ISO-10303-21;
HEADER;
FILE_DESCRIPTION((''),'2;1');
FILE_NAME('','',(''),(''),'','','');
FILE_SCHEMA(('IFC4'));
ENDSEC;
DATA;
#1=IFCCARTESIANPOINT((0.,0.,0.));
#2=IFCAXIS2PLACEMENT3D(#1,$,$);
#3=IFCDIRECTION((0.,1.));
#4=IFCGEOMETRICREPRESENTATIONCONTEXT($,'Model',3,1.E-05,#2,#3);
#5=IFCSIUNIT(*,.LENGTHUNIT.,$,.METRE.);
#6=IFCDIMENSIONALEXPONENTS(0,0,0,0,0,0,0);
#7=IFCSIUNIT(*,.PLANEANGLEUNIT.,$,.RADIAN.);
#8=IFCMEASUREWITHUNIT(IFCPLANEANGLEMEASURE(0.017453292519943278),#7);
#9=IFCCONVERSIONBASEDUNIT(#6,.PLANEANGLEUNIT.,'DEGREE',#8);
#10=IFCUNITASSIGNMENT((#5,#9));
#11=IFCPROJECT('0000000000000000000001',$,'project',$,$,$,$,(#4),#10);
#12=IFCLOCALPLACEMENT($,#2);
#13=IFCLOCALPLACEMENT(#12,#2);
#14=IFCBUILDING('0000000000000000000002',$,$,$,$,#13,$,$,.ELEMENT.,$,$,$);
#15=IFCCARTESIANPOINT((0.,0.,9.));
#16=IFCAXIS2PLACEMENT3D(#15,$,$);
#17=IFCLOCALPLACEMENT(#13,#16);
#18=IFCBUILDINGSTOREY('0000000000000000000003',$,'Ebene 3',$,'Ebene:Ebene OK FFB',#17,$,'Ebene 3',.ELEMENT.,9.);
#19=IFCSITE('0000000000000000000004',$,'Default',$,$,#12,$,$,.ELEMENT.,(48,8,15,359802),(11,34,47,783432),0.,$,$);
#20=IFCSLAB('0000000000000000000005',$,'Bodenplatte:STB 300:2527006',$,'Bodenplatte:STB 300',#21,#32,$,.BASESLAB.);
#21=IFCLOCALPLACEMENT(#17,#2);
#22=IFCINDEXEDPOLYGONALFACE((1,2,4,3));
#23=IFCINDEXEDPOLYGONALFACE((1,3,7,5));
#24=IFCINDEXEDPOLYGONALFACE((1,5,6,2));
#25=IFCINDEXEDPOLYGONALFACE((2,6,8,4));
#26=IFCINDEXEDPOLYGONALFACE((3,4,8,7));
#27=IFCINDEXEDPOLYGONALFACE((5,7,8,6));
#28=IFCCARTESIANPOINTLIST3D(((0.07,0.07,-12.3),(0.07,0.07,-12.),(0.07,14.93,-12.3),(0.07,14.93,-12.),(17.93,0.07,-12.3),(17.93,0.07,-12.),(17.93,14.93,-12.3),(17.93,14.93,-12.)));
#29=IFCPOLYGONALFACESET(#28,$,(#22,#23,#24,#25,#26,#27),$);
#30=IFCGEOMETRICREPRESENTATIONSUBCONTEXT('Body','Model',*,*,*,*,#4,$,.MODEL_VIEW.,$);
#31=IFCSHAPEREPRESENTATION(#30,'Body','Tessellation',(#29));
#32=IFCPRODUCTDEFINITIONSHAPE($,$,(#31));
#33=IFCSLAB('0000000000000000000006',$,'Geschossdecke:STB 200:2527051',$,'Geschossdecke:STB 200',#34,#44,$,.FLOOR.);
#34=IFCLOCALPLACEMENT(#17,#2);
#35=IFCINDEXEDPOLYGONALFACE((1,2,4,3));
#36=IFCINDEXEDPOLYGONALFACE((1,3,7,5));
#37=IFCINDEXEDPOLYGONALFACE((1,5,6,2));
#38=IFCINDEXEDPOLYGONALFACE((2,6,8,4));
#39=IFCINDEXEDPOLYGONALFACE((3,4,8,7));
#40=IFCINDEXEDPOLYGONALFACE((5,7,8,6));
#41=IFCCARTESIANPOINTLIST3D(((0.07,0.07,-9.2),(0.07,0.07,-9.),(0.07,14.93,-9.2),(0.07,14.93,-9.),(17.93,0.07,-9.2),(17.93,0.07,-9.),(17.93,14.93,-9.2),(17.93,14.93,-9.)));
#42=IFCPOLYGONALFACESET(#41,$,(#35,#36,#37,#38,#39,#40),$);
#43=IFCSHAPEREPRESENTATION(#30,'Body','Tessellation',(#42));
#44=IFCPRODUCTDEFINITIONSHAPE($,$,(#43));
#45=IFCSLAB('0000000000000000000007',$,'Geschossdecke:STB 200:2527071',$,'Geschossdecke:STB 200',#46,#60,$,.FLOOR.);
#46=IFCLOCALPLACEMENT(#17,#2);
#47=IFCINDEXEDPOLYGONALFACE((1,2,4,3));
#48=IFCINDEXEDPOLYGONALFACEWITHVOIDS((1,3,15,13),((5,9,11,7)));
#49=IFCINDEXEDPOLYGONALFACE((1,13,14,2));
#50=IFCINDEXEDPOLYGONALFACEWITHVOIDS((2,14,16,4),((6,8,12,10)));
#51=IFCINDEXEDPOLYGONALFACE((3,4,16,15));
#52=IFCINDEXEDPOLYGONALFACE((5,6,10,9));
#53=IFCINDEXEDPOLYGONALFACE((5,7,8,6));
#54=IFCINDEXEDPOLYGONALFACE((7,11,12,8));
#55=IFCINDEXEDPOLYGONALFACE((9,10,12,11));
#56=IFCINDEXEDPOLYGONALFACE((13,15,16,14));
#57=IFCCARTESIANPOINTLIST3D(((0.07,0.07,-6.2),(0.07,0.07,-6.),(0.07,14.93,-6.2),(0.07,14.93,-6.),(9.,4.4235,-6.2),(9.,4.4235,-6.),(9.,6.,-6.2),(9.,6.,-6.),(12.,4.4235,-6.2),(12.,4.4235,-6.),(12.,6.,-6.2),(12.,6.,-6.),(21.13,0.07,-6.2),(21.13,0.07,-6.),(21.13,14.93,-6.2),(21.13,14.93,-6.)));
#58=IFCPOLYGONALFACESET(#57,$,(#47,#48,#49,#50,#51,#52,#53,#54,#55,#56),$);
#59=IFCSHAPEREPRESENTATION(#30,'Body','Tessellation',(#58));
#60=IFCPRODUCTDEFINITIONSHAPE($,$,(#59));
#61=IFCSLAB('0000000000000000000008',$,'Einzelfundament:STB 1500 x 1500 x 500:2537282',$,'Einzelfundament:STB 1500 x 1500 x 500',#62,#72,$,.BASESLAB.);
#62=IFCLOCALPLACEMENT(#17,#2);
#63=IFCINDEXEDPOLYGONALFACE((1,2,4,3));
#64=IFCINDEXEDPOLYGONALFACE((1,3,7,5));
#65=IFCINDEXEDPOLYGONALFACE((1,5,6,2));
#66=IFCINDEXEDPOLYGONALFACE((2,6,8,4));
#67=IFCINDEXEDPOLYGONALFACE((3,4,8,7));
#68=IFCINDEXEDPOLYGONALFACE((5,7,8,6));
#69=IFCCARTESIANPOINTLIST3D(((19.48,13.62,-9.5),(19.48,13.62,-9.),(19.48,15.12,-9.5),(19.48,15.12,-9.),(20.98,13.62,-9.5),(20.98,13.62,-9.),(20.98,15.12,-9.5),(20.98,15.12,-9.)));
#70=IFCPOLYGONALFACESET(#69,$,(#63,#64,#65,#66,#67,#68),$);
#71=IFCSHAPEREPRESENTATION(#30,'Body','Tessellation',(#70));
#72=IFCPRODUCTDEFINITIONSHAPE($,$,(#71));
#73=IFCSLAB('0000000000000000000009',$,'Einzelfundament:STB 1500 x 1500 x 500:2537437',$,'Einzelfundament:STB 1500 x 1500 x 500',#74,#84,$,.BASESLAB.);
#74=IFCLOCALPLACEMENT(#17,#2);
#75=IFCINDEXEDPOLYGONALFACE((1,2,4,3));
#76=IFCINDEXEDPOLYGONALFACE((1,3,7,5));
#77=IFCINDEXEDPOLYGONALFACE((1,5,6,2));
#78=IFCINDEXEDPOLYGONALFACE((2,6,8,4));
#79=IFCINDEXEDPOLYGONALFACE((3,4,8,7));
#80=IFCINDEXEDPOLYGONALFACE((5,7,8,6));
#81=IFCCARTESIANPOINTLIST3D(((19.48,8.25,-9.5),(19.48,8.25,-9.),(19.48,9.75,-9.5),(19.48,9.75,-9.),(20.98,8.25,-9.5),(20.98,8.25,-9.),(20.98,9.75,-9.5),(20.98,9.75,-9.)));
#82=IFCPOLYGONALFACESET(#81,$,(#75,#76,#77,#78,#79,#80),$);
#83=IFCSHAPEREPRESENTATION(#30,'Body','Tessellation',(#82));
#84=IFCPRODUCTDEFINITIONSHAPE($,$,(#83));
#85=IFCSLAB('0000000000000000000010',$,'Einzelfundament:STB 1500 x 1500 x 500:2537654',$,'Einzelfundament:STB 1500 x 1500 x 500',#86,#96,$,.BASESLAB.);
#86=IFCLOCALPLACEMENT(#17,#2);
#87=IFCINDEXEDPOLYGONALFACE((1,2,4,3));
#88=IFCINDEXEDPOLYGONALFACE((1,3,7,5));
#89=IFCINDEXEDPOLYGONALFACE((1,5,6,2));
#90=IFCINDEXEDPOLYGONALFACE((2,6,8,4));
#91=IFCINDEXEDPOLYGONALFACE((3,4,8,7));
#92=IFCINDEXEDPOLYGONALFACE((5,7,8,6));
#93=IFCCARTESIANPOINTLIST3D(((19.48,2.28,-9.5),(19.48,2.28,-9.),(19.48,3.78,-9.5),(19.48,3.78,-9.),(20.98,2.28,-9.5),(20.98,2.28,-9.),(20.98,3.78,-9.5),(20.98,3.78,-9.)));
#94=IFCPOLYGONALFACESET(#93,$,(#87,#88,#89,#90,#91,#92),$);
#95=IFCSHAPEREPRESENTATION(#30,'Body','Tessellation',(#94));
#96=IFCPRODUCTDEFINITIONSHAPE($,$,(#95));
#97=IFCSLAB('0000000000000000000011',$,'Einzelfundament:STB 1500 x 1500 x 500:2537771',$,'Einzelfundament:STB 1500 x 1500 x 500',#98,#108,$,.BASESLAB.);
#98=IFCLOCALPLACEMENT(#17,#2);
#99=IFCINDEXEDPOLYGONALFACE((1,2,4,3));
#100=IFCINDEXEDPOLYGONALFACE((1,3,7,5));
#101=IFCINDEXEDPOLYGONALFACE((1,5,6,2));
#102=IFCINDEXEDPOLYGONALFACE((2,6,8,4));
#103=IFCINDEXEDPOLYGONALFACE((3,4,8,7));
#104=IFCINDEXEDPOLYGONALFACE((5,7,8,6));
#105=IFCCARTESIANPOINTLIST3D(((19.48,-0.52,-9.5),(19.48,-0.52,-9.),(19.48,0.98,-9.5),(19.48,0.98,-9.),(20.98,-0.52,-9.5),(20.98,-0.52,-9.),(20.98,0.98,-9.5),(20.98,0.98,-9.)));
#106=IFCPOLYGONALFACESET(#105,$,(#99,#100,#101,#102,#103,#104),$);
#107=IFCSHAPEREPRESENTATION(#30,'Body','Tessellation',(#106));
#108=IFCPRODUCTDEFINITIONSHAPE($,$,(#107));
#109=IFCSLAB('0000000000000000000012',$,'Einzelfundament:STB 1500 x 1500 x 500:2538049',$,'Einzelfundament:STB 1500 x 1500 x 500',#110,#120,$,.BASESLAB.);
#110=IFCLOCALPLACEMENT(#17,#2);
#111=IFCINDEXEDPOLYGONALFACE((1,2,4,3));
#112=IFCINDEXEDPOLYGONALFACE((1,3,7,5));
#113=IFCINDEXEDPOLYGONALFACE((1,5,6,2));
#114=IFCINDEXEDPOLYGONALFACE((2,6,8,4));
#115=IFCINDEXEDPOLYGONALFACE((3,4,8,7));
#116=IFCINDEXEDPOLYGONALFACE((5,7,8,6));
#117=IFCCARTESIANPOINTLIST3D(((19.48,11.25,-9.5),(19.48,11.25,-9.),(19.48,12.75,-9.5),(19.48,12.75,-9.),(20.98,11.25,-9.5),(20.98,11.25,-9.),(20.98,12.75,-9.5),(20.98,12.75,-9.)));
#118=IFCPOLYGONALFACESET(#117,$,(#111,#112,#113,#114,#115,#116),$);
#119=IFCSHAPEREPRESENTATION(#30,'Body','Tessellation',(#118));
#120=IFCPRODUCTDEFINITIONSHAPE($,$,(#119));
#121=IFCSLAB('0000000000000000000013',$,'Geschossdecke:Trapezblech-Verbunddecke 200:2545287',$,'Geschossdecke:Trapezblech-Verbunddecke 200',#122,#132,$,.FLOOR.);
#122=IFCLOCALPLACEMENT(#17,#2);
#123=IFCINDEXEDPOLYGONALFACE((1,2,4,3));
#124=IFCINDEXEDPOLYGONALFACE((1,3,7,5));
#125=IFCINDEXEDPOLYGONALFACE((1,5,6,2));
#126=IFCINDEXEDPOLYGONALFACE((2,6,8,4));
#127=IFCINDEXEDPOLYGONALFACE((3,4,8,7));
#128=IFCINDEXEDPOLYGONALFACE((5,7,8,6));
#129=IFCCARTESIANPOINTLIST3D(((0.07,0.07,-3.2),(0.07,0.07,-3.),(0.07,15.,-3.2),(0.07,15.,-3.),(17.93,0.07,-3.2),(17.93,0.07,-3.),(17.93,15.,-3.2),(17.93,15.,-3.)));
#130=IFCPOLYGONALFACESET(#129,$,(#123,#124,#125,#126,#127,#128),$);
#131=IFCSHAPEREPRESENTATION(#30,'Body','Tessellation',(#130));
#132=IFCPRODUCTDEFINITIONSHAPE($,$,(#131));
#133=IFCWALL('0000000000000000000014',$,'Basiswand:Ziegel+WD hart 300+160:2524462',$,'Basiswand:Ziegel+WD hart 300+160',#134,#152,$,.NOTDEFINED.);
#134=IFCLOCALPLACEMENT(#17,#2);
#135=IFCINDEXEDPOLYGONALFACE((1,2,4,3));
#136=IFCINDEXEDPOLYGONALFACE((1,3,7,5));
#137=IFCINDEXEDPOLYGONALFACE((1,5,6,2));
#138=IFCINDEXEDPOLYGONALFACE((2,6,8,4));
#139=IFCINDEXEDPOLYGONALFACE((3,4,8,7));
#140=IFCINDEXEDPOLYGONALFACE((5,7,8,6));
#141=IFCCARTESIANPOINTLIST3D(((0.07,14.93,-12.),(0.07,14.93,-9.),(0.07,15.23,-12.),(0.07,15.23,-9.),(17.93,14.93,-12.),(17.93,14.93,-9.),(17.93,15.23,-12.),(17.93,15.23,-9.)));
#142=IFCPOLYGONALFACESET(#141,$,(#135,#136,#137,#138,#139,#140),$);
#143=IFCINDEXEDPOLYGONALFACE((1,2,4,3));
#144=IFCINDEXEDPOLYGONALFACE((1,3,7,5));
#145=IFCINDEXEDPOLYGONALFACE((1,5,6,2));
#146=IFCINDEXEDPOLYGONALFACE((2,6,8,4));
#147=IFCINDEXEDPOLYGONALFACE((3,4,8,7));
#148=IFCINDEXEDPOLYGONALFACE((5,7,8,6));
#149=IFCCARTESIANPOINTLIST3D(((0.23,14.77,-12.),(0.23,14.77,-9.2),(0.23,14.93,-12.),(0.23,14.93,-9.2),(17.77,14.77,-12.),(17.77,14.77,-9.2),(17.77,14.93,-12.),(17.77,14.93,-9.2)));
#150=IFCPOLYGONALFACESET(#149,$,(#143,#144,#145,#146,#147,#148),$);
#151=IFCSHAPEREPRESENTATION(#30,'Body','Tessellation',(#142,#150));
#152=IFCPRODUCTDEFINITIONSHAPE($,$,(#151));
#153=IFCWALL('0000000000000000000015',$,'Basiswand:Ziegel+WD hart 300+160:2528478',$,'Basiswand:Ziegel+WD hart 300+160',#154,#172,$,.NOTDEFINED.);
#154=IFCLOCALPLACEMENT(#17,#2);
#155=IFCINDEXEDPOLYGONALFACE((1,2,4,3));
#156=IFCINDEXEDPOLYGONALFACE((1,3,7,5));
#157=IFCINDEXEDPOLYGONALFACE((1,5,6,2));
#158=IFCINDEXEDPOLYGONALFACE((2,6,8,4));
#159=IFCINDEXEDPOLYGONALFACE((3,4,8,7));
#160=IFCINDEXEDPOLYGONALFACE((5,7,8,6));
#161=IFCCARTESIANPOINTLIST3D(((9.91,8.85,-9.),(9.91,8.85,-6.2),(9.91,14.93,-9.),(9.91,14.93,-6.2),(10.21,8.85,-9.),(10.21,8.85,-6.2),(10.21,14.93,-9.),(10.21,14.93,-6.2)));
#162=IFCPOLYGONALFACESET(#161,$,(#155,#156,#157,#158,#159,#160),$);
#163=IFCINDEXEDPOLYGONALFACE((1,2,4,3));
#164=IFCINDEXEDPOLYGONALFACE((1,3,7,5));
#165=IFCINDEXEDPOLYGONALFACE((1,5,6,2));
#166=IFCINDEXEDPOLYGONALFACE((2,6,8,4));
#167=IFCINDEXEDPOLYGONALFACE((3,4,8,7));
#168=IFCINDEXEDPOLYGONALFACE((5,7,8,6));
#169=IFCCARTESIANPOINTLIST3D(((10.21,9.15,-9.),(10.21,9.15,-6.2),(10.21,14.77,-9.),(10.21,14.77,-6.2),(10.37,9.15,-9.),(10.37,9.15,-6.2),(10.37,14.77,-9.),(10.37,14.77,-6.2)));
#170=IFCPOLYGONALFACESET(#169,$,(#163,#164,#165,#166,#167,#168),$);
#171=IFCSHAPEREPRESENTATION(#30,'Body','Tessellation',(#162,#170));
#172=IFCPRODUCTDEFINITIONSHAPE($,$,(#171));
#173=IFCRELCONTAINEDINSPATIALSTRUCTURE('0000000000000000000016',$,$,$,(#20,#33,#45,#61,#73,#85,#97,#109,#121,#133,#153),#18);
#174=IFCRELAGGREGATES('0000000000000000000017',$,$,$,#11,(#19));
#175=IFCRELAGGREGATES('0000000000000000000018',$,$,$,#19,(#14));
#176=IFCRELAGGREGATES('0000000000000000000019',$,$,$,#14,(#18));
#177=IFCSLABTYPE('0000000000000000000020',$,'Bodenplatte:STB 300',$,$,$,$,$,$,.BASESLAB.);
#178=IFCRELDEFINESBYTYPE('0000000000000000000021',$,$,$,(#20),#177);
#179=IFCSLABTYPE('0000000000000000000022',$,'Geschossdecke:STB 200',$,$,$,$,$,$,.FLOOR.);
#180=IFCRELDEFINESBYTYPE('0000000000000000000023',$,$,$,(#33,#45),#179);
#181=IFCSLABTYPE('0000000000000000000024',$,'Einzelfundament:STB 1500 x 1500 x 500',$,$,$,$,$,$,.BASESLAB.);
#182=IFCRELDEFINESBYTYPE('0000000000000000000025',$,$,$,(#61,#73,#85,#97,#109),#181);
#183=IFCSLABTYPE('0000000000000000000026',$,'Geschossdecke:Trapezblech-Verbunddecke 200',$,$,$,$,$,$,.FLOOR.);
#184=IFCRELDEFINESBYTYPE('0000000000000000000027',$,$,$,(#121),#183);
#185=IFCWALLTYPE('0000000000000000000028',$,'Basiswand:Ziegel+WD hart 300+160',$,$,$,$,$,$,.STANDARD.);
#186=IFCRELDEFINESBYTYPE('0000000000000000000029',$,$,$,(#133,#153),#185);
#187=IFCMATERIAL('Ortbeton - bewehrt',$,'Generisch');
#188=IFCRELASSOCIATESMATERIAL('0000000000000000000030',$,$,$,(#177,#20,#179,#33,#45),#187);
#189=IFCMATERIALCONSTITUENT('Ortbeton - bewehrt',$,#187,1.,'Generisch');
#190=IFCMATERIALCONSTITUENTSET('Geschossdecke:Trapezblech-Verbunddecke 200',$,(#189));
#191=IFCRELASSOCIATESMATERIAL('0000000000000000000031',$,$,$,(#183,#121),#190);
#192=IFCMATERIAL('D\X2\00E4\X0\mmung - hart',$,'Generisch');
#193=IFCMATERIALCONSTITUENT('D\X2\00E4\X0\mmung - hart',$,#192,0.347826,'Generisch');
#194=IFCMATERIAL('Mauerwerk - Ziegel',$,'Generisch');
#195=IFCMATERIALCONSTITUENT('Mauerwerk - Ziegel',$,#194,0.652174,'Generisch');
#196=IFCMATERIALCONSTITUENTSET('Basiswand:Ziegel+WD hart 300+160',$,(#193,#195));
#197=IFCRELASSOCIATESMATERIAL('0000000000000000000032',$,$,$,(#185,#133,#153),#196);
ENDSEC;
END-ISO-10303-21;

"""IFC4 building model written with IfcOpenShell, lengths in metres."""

from ifc_helpers import new_model, entity, si_unit, converted_unit, direction, frame, origin, place, context, subcontext, project, spatial, indexed_curve, outline, extrude, material, constituent, constituent_set, type_object, element, save


model = new_model("IFC4")

# Units and contexts
model_context = context("Model", 3, precision=1e-05, world=origin(), true_north=direction((0.0, 1.0)))
body_context = subcontext(model_context, "Body", "Model", "MODEL_VIEW")
ifc_project = project(units=[si_unit("LENGTHUNIT", "METRE"), converted_unit("PLANEANGLEUNIT", "DEGREE", entity("IfcPlaneAngleMeasure", 0.017453292519943278), si_unit("PLANEANGLEUNIT", "RADIAN"), dimensions=[0, 0, 0, 0, 0, 0, 0])], contexts=[model_context])

# Site, building, storey
site_placement = place(None, origin())
site = spatial("IfcSite", under=ifc_project, at=site_placement, Name="Default", CompositionType="ELEMENT", RefLatitude=(48, 8, 15, 359802), RefLongitude=(11, 34, 47, 783432), RefElevation=0.0)
building_placement = place(site_placement, origin())
building = spatial("IfcBuilding", under=site, at=building_placement, CompositionType="ELEMENT")
storey_placement = place(building_placement, frame((0.0, 0.0, 9.0)))
storey = spatial("IfcBuildingStorey", under=building, at=storey_placement, Name="Ebene 3", ObjectType="Ebene:Ebene OK FFB", LongName="Ebene 3", CompositionType="ELEMENT", Elevation=9.0)

# Slabs
ifc_material_1 = material(Name="Ortbeton - bewehrt", Category="Generisch")
slab_type_1 = type_object("IfcSlabType", Name="Bodenplatte:STB 300", PredefinedType="BASESLAB", material=ifc_material_1)
slab_1_placement = place(storey_placement, origin())
element("IfcSlab", 1, at=slab_1_placement, inside=storey, type_object=slab_type_1, material=ifc_material_1, Name="Bodenplatte:STB 300:2527006", ObjectType="Bodenplatte:STB 300", PredefinedType="BASESLAB", context=body_context, shape_type="SweptSolid", body=[
    extrude(outline(indexed_curve([(-7.43, -8.93), (7.43, -8.93), (7.43, 8.93), (-7.43, 8.93), (-7.43, -8.93)], self_intersect=False)), frame((9.0, 7.5, -12.0), z_axis=(0.0, 0.0, -1.0), x_axis=(0.0, 1.0, 0.0)), (0.0, 0.0, 1.0), 0.3),
])
slab_type_2 = type_object("IfcSlabType", Name="Geschossdecke:STB 200", PredefinedType="FLOOR", material=ifc_material_1)
slab_2_placement = place(storey_placement, origin())
element("IfcSlab", 2, at=slab_2_placement, inside=storey, type_object=slab_type_2, material=ifc_material_1, Name="Geschossdecke:STB 200:2527051", ObjectType="Geschossdecke:STB 200", PredefinedType="FLOOR", context=body_context, shape_type="SweptSolid", body=[
    extrude(outline(indexed_curve([(-7.43, -8.93), (7.43, -8.93), (7.43, 8.93), (-7.43, 8.93), (-7.43, -8.93)], self_intersect=False)), frame((9.0, 7.5, -9.0), z_axis=(0.0, 0.0, -1.0), x_axis=(0.0, 1.0, 0.0)), (0.0, 0.0, 1.0), 0.2),
])

# Slab, opening
slab_3_placement = place(storey_placement, origin())
slab_3 = element("IfcSlab", 3, at=slab_3_placement, inside=storey, type_object=slab_type_2, material=ifc_material_1, Name="Geschossdecke:STB 200:2527071", ObjectType="Geschossdecke:STB 200", PredefinedType="FLOOR", context=body_context, shape_type="SweptSolid", body=[
    extrude(outline(indexed_curve([(-10.53, -7.43), (10.53, -7.43), (10.53, 7.43), (-10.53, 7.43), (-10.53, -7.43)], self_intersect=False), holes=[indexed_curve([(1.4, -1.5), (1.4, -3.0765), (-1.6, -3.0765), (-1.6, -1.5), (1.4, -1.5)], self_intersect=False)]), frame((10.6, 7.5, -6.2)), (0.0, 0.0, 1.0), 0.2),
])
opening_1_placement = place(slab_3_placement, origin())
element("IfcOpeningElement", 4, at=opening_1_placement, cuts=slab_3, PredefinedType="OPENING", context=body_context, shape_type="SweptSolid", body=[
    extrude(outline(indexed_curve([(12.0, 6.0), (9.0, 6.0), (9.0, 4.4235), (12.0, 4.4235), (12.0, 6.0)], self_intersect=False)), frame((0.0, 0.0, -9.0)), (0.0, 0.0, -1.0), 14.86),
])

# Slabs
slab_type_3 = type_object("IfcSlabType", Name="Einzelfundament:STB 1500 x 1500 x 500", PredefinedType="BASESLAB")
slab_4_placement = place(storey_placement, origin())
element("IfcSlab", 5, at=slab_4_placement, inside=storey, type_object=slab_type_3, Name="Einzelfundament:STB 1500 x 1500 x 500:2537282", ObjectType="Einzelfundament:STB 1500 x 1500 x 500", PredefinedType="BASESLAB", context=body_context, shape_type="SweptSolid", body=[
    extrude(outline(indexed_curve([(-0.75, -0.75), (0.75, -0.75), (0.75, 0.75), (-0.75, 0.75), (-0.75, -0.75)], self_intersect=False)), frame((20.23, 14.37, -9.5), z_axis=(0.0, 0.0, 1.0), x_axis=(-1.0, 0.0, 0.0)), (0.0, 0.0, 1.0), 0.5),
])
slab_5_placement = place(storey_placement, origin())
element("IfcSlab", 6, at=slab_5_placement, inside=storey, type_object=slab_type_3, Name="Einzelfundament:STB 1500 x 1500 x 500:2537437", ObjectType="Einzelfundament:STB 1500 x 1500 x 500", PredefinedType="BASESLAB", context=body_context, shape_type="SweptSolid", body=[
    extrude(outline(indexed_curve([(-0.75, -0.75), (0.75, -0.75), (0.75, 0.75), (-0.75, 0.75), (-0.75, -0.75)], self_intersect=False)), frame((20.23, 9.0, -9.5), z_axis=(0.0, 0.0, 1.0), x_axis=(-1.0, 0.0, 0.0)), (0.0, 0.0, 1.0), 0.5),
])
slab_6_placement = place(storey_placement, origin())
element("IfcSlab", 7, at=slab_6_placement, inside=storey, type_object=slab_type_3, Name="Einzelfundament:STB 1500 x 1500 x 500:2537654", ObjectType="Einzelfundament:STB 1500 x 1500 x 500", PredefinedType="BASESLAB", context=body_context, shape_type="SweptSolid", body=[
    extrude(outline(indexed_curve([(-0.75, -0.75), (0.75, -0.75), (0.75, 0.75), (-0.75, 0.75), (-0.75, -0.75)], self_intersect=False)), frame((20.23, 3.03, -9.5), z_axis=(0.0, 0.0, 1.0), x_axis=(-1.0, 0.0, 0.0)), (0.0, 0.0, 1.0), 0.5),
])
slab_7_placement = place(storey_placement, origin())
element("IfcSlab", 8, at=slab_7_placement, inside=storey, type_object=slab_type_3, Name="Einzelfundament:STB 1500 x 1500 x 500:2537771", ObjectType="Einzelfundament:STB 1500 x 1500 x 500", PredefinedType="BASESLAB", context=body_context, shape_type="SweptSolid", body=[
    extrude(outline(indexed_curve([(-0.75, -0.75), (0.75, -0.75), (0.75, 0.75), (-0.75, 0.75), (-0.75, -0.75)], self_intersect=False)), frame((20.23, 0.23, -9.5), z_axis=(0.0, 0.0, 1.0), x_axis=(-1.0, 0.0, 0.0)), (0.0, 0.0, 1.0), 0.5),
])
slab_8_placement = place(storey_placement, origin())
element("IfcSlab", 9, at=slab_8_placement, inside=storey, type_object=slab_type_3, Name="Einzelfundament:STB 1500 x 1500 x 500:2538049", ObjectType="Einzelfundament:STB 1500 x 1500 x 500", PredefinedType="BASESLAB", context=body_context, shape_type="SweptSolid", body=[
    extrude(outline(indexed_curve([(-0.75, -0.75), (0.75, -0.75), (0.75, 0.75), (-0.75, 0.75), (-0.75, -0.75)], self_intersect=False)), frame((20.23, 12.0, -9.5), z_axis=(0.0, 0.0, 1.0), x_axis=(-1.0, 0.0, 0.0)), (0.0, 0.0, 1.0), 0.5),
])
ifc_constituent_1 = constituent(ifc_material_1, Name="Ortbeton - bewehrt", Category="Generisch", fraction=1.0)
ifc_constituent_set_1 = constituent_set(constituents=[ifc_constituent_1], Name="Geschossdecke:Trapezblech-Verbunddecke 200")
slab_type_4 = type_object("IfcSlabType", Name="Geschossdecke:Trapezblech-Verbunddecke 200", PredefinedType="FLOOR", material=ifc_constituent_set_1)
slab_9_placement = place(storey_placement, origin())
element("IfcSlab", 10, at=slab_9_placement, inside=storey, type_object=slab_type_4, material=ifc_constituent_set_1, Name="Geschossdecke:Trapezblech-Verbunddecke 200:2545287", ObjectType="Geschossdecke:Trapezblech-Verbunddecke 200", PredefinedType="FLOOR", context=body_context, shape_type="SweptSolid", body=[
    extrude(outline(indexed_curve([(-7.465, -8.93), (7.465, -8.93), (7.465, 8.93), (-7.465, 8.93), (-7.465, -8.93)], self_intersect=False)), frame((9.0, 7.535, -3.0), z_axis=(0.0, 0.0, -1.0), x_axis=(0.0, 1.0, 0.0)), (0.0, 0.0, 1.0), 0.2),
])

# Wall
ifc_material_2 = material(Name="Dämmung - hart", Category="Generisch")
ifc_constituent_2 = constituent(ifc_material_2, Name="Dämmung - hart", Category="Generisch", fraction=0.347826)
ifc_material_3 = material(Name="Mauerwerk - Ziegel", Category="Generisch")
ifc_constituent_3 = constituent(ifc_material_3, Name="Mauerwerk - Ziegel", Category="Generisch", fraction=0.652174)
ifc_constituent_set_2 = constituent_set(constituents=[ifc_constituent_2, ifc_constituent_3], Name="Basiswand:Ziegel+WD hart 300+160")
wall_type_1 = type_object("IfcWallType", Name="Basiswand:Ziegel+WD hart 300+160", PredefinedType="STANDARD", material=ifc_constituent_set_2)
wall_1_placement = place(storey_placement, frame((17.77, 15.0, -12.0), z_axis=(0.0, 0.0, 1.0), x_axis=(-1.0, 0.0, 0.0)))
element("IfcWall", 11, at=wall_1_placement, inside=storey, type_object=wall_type_1, material=ifc_constituent_set_2, Name="Basiswand:Ziegel+WD hart 300+160:2524462", ObjectType="Basiswand:Ziegel+WD hart 300+160", PredefinedType="NOTDEFINED", context=body_context, shape_type="SweptSolid", body=[
    extrude(outline(indexed_curve([(-0.15, -8.93), (0.15, -8.93), (0.15, 8.93), (-0.15, 8.93), (-0.15, -8.93)], self_intersect=False)), frame((8.77, -0.08, 0.0), z_axis=(0.0, 0.0, 1.0), x_axis=(0.0, 1.0, 0.0)), (0.0, 0.0, 1.0), 3.0),
    extrude(outline(indexed_curve([(-0.08, -8.77), (0.08, -8.77), (0.08, 8.77), (-0.08, 8.77), (-0.08, -8.77)], self_intersect=False)), frame((8.77, 0.15, 0.0), z_axis=(0.0, 0.0, 1.0), x_axis=(0.0, -1.0, 0.0)), (0.0, 0.0, 1.0), 2.8),
])

# Wall
wall_2_placement = place(storey_placement, frame((10.14, 14.77, -9.0), z_axis=(0.0, 0.0, 1.0), x_axis=(0.0, -1.0, 0.0)))
element("IfcWall", 12, at=wall_2_placement, inside=storey, type_object=wall_type_1, material=ifc_constituent_set_2, Name="Basiswand:Ziegel+WD hart 300+160:2528478", ObjectType="Basiswand:Ziegel+WD hart 300+160", PredefinedType="NOTDEFINED", context=body_context, shape_type="SweptSolid", body=[
    extrude(outline(indexed_curve([(-1.4, -3.04), (1.4, -3.04), (1.4, 3.04), (-1.4, 3.04), (-1.4, -3.04)], self_intersect=False)), frame((2.88, -0.23, 1.4), z_axis=(0.0, 1.0, 0.0), x_axis=(0.0, 0.0, 1.0)), (0.0, 0.0, 1.0), 0.3),
    extrude(outline(indexed_curve([(-1.4, -2.81), (1.4, -2.81), (1.4, 2.81), (-1.4, 2.81), (-1.4, -2.81)], self_intersect=False)), frame((2.81, 0.07, 1.4), z_axis=(0.0, 1.0, 0.0), x_axis=(0.0, 0.0, 1.0)), (0.0, 0.0, 1.0), 0.16),
])

save(model, "model.ifc")
